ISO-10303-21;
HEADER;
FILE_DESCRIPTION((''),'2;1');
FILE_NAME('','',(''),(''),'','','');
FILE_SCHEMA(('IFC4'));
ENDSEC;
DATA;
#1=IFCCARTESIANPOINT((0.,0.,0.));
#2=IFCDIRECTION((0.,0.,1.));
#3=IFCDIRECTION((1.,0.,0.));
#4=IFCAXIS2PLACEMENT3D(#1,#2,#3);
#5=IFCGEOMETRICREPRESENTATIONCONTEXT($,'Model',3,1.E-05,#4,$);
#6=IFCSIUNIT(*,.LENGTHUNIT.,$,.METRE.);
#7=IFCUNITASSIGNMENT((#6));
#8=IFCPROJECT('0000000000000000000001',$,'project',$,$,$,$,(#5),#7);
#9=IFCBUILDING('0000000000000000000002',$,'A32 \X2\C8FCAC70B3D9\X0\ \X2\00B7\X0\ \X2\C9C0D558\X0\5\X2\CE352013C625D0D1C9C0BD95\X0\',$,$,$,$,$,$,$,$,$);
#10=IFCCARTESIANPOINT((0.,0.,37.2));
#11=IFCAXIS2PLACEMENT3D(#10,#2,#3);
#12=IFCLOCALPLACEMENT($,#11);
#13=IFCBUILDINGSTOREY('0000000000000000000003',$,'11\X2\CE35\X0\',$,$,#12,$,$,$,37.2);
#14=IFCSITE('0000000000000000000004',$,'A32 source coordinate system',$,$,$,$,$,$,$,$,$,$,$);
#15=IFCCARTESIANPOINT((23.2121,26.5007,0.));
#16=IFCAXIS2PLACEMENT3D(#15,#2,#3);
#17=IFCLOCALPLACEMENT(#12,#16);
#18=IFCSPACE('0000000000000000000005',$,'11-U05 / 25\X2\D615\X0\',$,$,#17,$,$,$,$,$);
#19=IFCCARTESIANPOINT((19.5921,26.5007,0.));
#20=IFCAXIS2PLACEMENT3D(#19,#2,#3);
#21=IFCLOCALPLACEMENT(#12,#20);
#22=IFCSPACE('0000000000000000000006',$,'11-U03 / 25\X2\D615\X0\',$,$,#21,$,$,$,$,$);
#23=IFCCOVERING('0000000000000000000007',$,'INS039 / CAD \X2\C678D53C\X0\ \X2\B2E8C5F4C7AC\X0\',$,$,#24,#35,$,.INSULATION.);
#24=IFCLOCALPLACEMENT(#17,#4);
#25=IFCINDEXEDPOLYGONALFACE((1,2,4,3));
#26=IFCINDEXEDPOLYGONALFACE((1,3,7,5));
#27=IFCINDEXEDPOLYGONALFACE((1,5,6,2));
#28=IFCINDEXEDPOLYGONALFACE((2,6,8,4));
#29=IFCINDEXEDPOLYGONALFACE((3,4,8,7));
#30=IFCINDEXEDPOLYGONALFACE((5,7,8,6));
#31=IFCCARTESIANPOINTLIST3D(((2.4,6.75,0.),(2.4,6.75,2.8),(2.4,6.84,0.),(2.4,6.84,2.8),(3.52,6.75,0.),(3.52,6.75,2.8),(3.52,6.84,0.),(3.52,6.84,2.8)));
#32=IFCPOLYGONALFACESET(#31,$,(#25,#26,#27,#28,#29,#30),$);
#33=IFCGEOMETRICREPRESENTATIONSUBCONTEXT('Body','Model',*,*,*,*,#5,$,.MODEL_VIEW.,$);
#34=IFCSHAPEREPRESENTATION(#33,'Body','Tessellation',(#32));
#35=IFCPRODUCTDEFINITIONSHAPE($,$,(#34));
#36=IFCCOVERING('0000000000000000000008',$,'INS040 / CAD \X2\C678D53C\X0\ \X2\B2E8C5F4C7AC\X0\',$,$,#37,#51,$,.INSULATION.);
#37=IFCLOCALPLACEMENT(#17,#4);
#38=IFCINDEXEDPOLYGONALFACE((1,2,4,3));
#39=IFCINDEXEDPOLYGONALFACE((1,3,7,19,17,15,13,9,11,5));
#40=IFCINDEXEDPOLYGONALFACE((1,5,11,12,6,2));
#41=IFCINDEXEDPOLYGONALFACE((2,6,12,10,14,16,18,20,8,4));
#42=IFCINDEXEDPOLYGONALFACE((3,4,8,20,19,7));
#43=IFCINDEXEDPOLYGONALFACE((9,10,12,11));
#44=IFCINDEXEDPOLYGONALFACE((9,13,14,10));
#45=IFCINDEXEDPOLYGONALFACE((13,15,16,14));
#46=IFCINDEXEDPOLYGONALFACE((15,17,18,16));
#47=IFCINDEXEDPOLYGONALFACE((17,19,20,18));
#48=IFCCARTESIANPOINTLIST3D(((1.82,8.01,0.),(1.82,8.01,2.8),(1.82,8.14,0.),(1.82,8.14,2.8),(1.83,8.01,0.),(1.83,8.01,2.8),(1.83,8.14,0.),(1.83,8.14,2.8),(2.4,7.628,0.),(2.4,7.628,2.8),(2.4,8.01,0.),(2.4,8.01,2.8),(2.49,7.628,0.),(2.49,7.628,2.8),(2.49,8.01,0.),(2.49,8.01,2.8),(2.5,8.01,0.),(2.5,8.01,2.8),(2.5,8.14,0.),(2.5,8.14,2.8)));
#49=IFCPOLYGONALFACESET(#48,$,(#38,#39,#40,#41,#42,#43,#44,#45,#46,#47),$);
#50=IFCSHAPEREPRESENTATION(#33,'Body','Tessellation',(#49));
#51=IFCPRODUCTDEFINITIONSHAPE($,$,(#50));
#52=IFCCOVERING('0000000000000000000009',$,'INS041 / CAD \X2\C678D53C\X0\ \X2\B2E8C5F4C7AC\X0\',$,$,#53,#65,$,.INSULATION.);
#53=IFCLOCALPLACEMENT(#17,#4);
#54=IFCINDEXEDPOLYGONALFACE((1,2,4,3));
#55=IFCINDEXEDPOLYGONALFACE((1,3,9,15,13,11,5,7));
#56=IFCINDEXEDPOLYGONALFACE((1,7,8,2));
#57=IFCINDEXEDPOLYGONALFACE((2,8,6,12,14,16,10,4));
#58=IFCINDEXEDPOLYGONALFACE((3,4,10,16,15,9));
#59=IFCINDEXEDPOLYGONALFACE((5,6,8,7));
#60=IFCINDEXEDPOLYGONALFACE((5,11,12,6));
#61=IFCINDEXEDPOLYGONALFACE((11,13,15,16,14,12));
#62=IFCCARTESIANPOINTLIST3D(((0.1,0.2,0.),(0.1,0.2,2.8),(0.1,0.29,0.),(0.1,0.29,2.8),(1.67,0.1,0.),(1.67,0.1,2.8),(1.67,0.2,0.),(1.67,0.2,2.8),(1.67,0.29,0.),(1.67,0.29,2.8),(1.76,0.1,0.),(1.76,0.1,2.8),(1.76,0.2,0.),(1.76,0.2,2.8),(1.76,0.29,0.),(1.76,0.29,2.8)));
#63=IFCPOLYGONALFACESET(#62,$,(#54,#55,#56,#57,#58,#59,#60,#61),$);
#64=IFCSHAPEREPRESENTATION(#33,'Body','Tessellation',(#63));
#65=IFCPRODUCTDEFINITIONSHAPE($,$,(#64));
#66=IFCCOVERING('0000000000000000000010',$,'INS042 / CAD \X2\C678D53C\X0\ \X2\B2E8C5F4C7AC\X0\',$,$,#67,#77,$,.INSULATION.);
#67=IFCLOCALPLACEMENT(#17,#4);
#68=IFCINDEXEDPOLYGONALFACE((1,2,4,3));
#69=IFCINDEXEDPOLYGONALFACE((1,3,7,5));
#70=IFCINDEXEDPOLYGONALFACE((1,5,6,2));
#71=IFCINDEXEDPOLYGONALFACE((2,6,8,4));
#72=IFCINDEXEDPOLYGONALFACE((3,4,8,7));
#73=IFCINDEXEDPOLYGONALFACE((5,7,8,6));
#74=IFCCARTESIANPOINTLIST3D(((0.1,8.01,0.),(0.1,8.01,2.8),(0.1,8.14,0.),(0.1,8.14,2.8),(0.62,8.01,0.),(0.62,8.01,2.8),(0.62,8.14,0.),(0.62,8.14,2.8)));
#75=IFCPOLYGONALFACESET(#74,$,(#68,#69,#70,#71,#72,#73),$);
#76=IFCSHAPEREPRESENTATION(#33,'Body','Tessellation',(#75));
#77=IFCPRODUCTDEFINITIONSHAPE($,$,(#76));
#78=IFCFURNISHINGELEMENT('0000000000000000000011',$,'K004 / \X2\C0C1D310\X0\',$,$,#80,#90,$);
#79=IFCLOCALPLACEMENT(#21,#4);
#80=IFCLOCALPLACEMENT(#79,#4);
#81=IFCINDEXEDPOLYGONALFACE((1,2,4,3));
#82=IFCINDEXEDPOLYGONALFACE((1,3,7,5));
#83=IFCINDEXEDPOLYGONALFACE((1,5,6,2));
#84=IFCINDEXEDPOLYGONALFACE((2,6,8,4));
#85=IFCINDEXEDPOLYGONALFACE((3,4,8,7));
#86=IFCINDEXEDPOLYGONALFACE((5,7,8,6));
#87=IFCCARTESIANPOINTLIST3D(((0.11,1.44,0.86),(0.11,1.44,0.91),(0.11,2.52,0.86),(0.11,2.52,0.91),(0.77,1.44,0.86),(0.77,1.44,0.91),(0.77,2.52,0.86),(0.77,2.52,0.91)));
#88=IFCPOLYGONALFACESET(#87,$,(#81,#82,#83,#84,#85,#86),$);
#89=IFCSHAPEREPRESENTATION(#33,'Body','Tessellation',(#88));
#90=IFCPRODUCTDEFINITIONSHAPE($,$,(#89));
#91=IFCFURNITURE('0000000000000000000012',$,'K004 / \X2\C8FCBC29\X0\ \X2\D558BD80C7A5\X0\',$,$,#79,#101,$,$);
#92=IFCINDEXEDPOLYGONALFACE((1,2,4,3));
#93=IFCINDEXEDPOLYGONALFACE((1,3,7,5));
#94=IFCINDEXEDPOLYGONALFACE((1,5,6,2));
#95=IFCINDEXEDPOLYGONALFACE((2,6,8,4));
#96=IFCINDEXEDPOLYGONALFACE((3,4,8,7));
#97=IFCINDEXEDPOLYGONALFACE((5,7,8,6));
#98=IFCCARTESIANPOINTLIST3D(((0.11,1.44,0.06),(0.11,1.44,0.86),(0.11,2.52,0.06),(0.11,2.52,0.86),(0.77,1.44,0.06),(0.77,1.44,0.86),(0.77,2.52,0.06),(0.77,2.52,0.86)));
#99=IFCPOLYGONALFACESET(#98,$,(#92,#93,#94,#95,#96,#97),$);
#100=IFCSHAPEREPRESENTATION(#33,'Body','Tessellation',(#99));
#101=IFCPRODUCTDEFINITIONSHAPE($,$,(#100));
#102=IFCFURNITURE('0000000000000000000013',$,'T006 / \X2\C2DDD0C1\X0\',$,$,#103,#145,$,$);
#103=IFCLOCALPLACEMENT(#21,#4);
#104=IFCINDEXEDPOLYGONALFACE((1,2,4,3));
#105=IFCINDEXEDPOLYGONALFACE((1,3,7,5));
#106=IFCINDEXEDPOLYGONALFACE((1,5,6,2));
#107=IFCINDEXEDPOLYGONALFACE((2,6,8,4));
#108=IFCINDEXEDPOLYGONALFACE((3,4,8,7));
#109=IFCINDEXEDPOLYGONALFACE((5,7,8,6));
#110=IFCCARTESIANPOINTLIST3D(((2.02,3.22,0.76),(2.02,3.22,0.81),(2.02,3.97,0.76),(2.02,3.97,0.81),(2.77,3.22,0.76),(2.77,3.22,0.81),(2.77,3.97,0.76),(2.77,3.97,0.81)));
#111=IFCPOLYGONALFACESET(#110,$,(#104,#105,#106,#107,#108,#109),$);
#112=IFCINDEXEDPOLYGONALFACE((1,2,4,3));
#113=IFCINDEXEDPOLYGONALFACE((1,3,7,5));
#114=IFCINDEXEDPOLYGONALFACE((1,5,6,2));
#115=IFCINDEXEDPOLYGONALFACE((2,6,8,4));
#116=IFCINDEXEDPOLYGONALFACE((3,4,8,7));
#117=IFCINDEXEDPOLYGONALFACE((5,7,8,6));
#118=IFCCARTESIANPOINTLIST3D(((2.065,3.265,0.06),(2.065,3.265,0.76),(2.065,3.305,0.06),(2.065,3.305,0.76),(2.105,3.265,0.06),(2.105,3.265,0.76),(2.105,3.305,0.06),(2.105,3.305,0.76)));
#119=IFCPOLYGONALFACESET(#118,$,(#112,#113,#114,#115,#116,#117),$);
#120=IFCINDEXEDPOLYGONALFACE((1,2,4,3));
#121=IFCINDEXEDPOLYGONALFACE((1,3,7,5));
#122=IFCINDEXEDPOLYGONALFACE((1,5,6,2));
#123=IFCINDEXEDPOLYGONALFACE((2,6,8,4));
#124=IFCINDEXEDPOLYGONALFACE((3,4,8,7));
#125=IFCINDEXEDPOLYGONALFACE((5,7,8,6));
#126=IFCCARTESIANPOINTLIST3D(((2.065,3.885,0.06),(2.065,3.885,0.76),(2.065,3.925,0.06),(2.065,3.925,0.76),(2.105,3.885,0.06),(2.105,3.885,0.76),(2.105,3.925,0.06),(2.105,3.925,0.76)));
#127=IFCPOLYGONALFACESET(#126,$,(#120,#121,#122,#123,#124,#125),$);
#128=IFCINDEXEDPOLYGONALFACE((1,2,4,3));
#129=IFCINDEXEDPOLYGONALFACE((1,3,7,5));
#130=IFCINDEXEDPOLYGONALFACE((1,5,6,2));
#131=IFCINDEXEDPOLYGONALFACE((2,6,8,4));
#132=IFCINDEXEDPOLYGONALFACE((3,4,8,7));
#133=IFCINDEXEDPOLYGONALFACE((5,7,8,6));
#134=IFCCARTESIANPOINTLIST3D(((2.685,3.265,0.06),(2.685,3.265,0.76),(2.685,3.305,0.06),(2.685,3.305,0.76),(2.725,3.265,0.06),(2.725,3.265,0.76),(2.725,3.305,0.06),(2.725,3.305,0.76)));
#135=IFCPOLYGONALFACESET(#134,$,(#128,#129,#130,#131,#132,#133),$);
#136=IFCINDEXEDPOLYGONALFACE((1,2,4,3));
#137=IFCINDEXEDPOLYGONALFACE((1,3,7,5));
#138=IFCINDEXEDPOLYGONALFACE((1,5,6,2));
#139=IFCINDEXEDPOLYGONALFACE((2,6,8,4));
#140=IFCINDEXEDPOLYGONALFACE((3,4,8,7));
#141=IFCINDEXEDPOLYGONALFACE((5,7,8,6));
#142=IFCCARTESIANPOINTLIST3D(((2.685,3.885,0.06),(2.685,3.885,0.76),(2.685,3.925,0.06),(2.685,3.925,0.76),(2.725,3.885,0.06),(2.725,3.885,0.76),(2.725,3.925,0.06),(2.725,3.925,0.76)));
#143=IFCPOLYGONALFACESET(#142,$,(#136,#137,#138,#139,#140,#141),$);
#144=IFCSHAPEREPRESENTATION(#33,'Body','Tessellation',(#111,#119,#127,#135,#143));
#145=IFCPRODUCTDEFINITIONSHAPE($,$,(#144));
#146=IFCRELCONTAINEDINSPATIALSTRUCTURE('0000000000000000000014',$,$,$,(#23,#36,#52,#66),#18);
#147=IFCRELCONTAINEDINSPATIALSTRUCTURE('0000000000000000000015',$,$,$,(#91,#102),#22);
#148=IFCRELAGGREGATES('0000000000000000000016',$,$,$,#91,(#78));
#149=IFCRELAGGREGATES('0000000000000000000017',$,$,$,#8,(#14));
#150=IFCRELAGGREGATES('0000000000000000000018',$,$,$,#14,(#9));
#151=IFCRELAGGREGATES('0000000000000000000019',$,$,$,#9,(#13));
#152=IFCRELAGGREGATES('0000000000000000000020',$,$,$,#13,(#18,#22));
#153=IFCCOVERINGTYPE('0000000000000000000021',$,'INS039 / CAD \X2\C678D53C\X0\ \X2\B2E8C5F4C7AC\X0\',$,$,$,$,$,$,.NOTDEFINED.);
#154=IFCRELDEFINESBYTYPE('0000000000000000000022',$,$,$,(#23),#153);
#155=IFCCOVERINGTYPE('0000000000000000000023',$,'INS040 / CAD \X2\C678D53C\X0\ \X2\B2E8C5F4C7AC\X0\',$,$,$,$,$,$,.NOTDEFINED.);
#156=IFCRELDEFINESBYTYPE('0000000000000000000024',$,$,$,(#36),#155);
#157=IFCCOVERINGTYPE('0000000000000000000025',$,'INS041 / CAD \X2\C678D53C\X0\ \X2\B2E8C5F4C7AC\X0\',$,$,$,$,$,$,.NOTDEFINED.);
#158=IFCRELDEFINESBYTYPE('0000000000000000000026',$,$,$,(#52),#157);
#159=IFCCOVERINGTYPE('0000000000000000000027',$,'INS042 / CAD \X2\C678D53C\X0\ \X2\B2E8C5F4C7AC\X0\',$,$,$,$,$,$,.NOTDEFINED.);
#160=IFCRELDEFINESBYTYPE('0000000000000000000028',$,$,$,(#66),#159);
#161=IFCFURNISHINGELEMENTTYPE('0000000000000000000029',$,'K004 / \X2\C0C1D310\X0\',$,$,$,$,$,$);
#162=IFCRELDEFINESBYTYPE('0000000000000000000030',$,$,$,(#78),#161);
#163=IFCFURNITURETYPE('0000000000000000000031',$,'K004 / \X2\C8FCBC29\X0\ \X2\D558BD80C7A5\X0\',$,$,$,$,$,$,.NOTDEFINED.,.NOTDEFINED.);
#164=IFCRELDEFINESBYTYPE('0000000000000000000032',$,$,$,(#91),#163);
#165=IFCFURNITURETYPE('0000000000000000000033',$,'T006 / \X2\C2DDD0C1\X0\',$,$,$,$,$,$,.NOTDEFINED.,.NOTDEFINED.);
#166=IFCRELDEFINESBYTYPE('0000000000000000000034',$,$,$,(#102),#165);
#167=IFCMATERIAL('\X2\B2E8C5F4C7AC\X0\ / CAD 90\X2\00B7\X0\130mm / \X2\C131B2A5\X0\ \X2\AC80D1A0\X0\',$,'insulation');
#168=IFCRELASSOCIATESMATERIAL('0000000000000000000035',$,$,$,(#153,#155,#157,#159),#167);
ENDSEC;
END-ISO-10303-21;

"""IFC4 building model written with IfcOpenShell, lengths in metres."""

from ifc_helpers import new_model, si_unit, frame, origin, origin_with_axes, place, context, subcontext, project, spatial, polyline, outline, extrude, source, transform, mapped, material, type_object, type_shapes, element, aggregate, save


model = new_model("IFC4")

# Units and contexts
model_context = context("Model", 3, precision=1e-05, world=origin_with_axes())
body_context = subcontext(model_context, "Body", "Model", "MODEL_VIEW")
ifc_project = project(units=[si_unit("LENGTHUNIT", "METRE")], contexts=[model_context])

# Site, building, storey, space
storey_placement = place(None, frame((0.0, 0.0, 37.2), z_axis=(0.0, 0.0, 1.0), x_axis=(1.0, 0.0, 0.0)))
space_1_placement = place(storey_placement, frame((23.2121, 26.5007, 0.0), z_axis=(0.0, 0.0, 1.0), x_axis=(1.0, 0.0, 0.0)))
site = spatial("IfcSite", under=ifc_project, Name="A32 source coordinate system")
building = spatial("IfcBuilding", under=site, Name="A32 주거동 · 지하5층–옥탑지붕")
storey = spatial("IfcBuildingStorey", under=building, at=storey_placement, Name="11층", Elevation=37.2)
space_1 = spatial("IfcSpace", under=storey, at=space_1_placement, Name="11-U05 / 25형")

# Shared definitions
space_2_placement = place(storey_placement, frame((19.5921, 26.5007, 0.0), z_axis=(0.0, 0.0, 1.0), x_axis=(1.0, 0.0, 0.0)))
space_2 = spatial("IfcSpace", under=storey, at=space_2_placement, Name="11-U03 / 25형")

# Coverings
ifc_material = material(Name="단열재 / CAD 90·130mm / 성능 검토", Category="insulation")
covering_type_1 = type_object("IfcCoveringType", Name="INS039 / CAD 외피 단열재", PredefinedType="NOTDEFINED", material=ifc_material)
shared_shape_1 = source(origin(), body_context, "Body", "SweptSolid", [
    extrude(outline(polyline([(2.4, 6.75), (2.4, 6.84), (3.52, 6.84), (3.52, 6.75), (2.4, 6.75)])), origin(), (0.0, 0.0, 1.0), 2.8),
])
type_shapes(covering_type_1, [shared_shape_1])
covering_1_placement = place(space_1_placement, origin_with_axes())
element("IfcCovering", 1, at=covering_1_placement, inside=space_1, type_object=covering_type_1, Name="INS039 / CAD 외피 단열재", PredefinedType="INSULATION", context=body_context, shape_type="MappedRepresentation", body=[
    mapped(shared_shape_1, transform((0.0, 0.0, 0.0), scale=1.0)),
])
covering_type_2 = type_object("IfcCoveringType", Name="INS040 / CAD 외피 단열재", PredefinedType="NOTDEFINED", material=ifc_material)
shared_shape_2 = source(origin(), body_context, "Body", "SweptSolid", [
    extrude(outline(polyline([(2.4, 7.628), (2.4, 8.01), (1.83, 8.01), (1.82, 8.01), (1.82, 8.14), (1.83, 8.14), (2.5, 8.14), (2.5, 8.01), (2.49, 8.01), (2.49, 7.628), (2.4, 7.628)])), origin(), (0.0, 0.0, 1.0), 2.8),
])
type_shapes(covering_type_2, [shared_shape_2])
covering_2_placement = place(space_1_placement, origin_with_axes())
element("IfcCovering", 2, at=covering_2_placement, inside=space_1, type_object=covering_type_2, Name="INS040 / CAD 외피 단열재", PredefinedType="INSULATION", context=body_context, shape_type="MappedRepresentation", body=[
    mapped(shared_shape_2, transform((0.0, 0.0, 0.0), scale=1.0)),
])
covering_type_3 = type_object("IfcCoveringType", Name="INS041 / CAD 외피 단열재", PredefinedType="NOTDEFINED", material=ifc_material)
shared_shape_3 = source(origin(), body_context, "Body", "SweptSolid", [
    extrude(outline(polyline([(1.67, 0.2), (0.1, 0.2), (0.1, 0.29), (1.67, 0.29), (1.76, 0.29), (1.76, 0.2), (1.76, 0.1), (1.67, 0.1), (1.67, 0.2)])), origin(), (0.0, 0.0, 1.0), 2.8),
])
type_shapes(covering_type_3, [shared_shape_3])
covering_3_placement = place(space_1_placement, origin_with_axes())
element("IfcCovering", 3, at=covering_3_placement, inside=space_1, type_object=covering_type_3, Name="INS041 / CAD 외피 단열재", PredefinedType="INSULATION", context=body_context, shape_type="MappedRepresentation", body=[
    mapped(shared_shape_3, transform((0.0, 0.0, 0.0), scale=1.0)),
])
covering_type_4 = type_object("IfcCoveringType", Name="INS042 / CAD 외피 단열재", PredefinedType="NOTDEFINED", material=ifc_material)
shared_shape_4 = source(origin(), body_context, "Body", "SweptSolid", [
    extrude(outline(polyline([(0.62, 8.14), (0.62, 8.01), (0.1, 8.01), (0.1, 8.14), (0.62, 8.14)])), origin(), (0.0, 0.0, 1.0), 2.8),
])
type_shapes(covering_type_4, [shared_shape_4])
covering_4_placement = place(space_1_placement, origin_with_axes())
element("IfcCovering", 4, at=covering_4_placement, inside=space_1, type_object=covering_type_4, Name="INS042 / CAD 외피 단열재", PredefinedType="INSULATION", context=body_context, shape_type="MappedRepresentation", body=[
    mapped(shared_shape_4, transform((0.0, 0.0, 0.0), scale=1.0)),
])

# Furnishing element
furnishing_element_type_1 = type_object("IfcFurnishingElementType", Name="K004 / 상판")
shared_shape_5 = source(origin(), body_context, "Body", "SweptSolid", [
    extrude(outline(polyline([(0.77, 2.52), (0.77, 1.44), (0.11, 1.44), (0.11, 2.52), (0.77, 2.52)])), frame((0.0, 0.0, 0.86)), (0.0, 0.0, 1.0), 0.05),
])
type_shapes(furnishing_element_type_1, [shared_shape_5])
furniture_1_placement = place(space_2_placement, origin_with_axes())
furnishing_1_placement = place(furniture_1_placement, origin_with_axes())
furnishing_1 = element("IfcFurnishingElement", 5, at=furnishing_1_placement, type_object=furnishing_element_type_1, Name="K004 / 상판", context=body_context, shape_type="MappedRepresentation", body=[
    mapped(shared_shape_5, transform((0.0, 0.0, 0.0), scale=1.0)),
])

# Furniture
furniture_type_1 = type_object("IfcFurnitureType", Name="K004 / 주방 하부장", AssemblyPlace="NOTDEFINED", PredefinedType="NOTDEFINED")
shared_shape_6 = source(origin(), body_context, "Body", "SweptSolid", [
    extrude(outline(polyline([(0.11, 2.52), (0.77, 2.52), (0.77, 1.44), (0.11, 1.44), (0.11, 2.52)])), frame((0.0, 0.0, 0.06)), (0.0, 0.0, 1.0), 0.8),
])
type_shapes(furniture_type_1, [shared_shape_6])
furniture_1 = element("IfcFurniture", 6, at=furniture_1_placement, inside=space_2, type_object=furniture_type_1, Name="K004 / 주방 하부장", context=body_context, shape_type="MappedRepresentation", body=[
    mapped(shared_shape_6, transform((0.0, 0.0, 0.0), scale=1.0)),
])
aggregate(furniture_1, [furnishing_1])
furniture_type_2 = type_object("IfcFurnitureType", Name="T006 / 식탁", AssemblyPlace="NOTDEFINED", PredefinedType="NOTDEFINED")
shared_shape_7 = source(origin(), body_context, "Body", "SweptSolid", [
    extrude(outline(polyline([(2.77, 3.22), (2.02, 3.22), (2.02, 3.97), (2.77, 3.97), (2.77, 3.22)])), frame((0.0, 0.0, 0.76)), (0.0, 0.0, 1.0), 0.05),
    extrude(outline(polyline([(2.065, 3.265), (2.065, 3.305), (2.105, 3.305), (2.105, 3.265), (2.065, 3.265)])), frame((0.0, 0.0, 0.06)), (0.0, 0.0, 1.0), 0.7),
    extrude(outline(polyline([(2.065, 3.885), (2.065, 3.925), (2.105, 3.925), (2.105, 3.885), (2.065, 3.885)])), frame((0.0, 0.0, 0.06)), (0.0, 0.0, 1.0), 0.7),
    extrude(outline(polyline([(2.685, 3.265), (2.685, 3.305), (2.725, 3.305), (2.725, 3.265), (2.685, 3.265)])), frame((0.0, 0.0, 0.06)), (0.0, 0.0, 1.0), 0.7),
    extrude(outline(polyline([(2.685, 3.885), (2.685, 3.925), (2.725, 3.925), (2.725, 3.885), (2.685, 3.885)])), frame((0.0, 0.0, 0.06)), (0.0, 0.0, 1.0), 0.7),
])
type_shapes(furniture_type_2, [shared_shape_7])
furniture_2_placement = place(space_2_placement, origin_with_axes())
element("IfcFurniture", 7, at=furniture_2_placement, inside=space_2, type_object=furniture_type_2, Name="T006 / 식탁", context=body_context, shape_type="MappedRepresentation", body=[
    mapped(shared_shape_7, transform((0.0, 0.0, 0.0), scale=1.0)),
])

save(model, "model.ifc")
